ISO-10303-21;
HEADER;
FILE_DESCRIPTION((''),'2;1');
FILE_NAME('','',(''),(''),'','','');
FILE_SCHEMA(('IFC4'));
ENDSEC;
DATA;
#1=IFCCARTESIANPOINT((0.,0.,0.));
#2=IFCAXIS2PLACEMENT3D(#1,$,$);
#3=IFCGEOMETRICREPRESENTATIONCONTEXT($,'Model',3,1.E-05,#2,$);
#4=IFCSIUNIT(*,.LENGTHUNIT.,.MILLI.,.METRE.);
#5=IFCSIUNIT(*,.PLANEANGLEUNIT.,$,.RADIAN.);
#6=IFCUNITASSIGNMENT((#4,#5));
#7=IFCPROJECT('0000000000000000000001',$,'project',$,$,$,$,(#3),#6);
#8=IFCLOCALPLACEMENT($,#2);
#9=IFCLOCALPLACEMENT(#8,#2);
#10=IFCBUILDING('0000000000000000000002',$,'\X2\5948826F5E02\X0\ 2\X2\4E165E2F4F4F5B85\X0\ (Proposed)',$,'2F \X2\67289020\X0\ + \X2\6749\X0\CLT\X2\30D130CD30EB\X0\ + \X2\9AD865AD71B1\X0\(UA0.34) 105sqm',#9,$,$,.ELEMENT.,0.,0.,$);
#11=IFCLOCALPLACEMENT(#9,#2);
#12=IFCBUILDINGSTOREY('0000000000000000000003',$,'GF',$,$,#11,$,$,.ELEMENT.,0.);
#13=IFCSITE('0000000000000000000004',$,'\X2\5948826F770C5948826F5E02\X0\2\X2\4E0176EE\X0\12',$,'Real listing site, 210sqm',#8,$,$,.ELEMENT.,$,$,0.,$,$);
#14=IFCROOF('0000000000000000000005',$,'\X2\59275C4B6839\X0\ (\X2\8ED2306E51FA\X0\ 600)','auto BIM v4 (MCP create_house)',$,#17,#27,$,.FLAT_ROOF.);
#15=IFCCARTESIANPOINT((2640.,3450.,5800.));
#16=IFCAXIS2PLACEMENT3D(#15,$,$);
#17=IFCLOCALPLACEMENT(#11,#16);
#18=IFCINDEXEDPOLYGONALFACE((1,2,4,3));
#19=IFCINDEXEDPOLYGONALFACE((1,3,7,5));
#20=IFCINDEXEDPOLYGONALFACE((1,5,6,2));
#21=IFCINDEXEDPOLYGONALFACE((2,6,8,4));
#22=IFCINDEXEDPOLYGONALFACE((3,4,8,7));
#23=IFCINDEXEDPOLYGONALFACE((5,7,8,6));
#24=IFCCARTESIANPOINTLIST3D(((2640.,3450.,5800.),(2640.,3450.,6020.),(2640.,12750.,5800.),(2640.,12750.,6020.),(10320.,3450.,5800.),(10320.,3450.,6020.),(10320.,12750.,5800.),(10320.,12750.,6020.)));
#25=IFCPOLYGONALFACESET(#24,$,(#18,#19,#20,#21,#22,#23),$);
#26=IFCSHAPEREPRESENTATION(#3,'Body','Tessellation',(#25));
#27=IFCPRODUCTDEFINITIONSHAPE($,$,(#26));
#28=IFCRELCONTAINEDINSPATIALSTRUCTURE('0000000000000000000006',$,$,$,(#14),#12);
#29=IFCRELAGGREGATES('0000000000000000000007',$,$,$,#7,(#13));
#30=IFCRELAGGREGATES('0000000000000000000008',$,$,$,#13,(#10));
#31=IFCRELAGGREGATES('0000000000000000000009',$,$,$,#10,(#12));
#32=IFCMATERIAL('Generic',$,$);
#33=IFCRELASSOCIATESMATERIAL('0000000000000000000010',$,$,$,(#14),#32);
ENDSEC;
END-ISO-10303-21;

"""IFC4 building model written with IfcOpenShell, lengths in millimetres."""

from ifc_helpers import new_model, si_unit, frame, frame_2d, origin, place, context, project, spatial, rectangle, extrude, material, element, save


model = new_model("IFC4")

# Units and contexts
model_context = context("Model", 3, precision=1e-05, world=origin())
ifc_project = project(units=[si_unit("LENGTHUNIT", "METRE", prefix="MILLI"), si_unit("PLANEANGLEUNIT", "RADIAN")], contexts=[model_context])

# Site, building, storey
site_placement = place(None, origin())
site = spatial("IfcSite", under=ifc_project, at=site_placement, Name="奈良県奈良市2丁目12", ObjectType="Real listing site, 210sqm", CompositionType="ELEMENT", RefElevation=0.0)
building_placement = place(site_placement, origin())
building = spatial("IfcBuilding", under=site, at=building_placement, Name="奈良市 2世帯住宅 (Proposed)", ObjectType="2F 木造 + 杉CLTパネル + 高断熱(UA0.34) 105sqm", CompositionType="ELEMENT", ElevationOfRefHeight=0.0, ElevationOfTerrain=0.0)
storey_placement = place(building_placement, origin())
storey = spatial("IfcBuildingStorey", under=building, at=storey_placement, Name="GF", CompositionType="ELEMENT", Elevation=0.0)

# Shared definitions
ifc_material = material(Name="Generic")

# Roof
roof_placement = place(storey_placement, frame((2640.0, 3450.0, 5800.0)))
element("IfcRoof", 1, at=roof_placement, inside=storey, material=ifc_material, Name="大屋根 (軒の出 600)", Description="auto BIM v4 (MCP create_house)", PredefinedType="FLAT_ROOF", context=model_context, shape_type="SweptSolid", body=[
    extrude(rectangle(XDim=7680.0, YDim=9300.0, at=frame_2d((3840.0, 4650.0))), frame((2640.0, 3450.0, 5800.0)), (0.0, 0.0, 1.0), 220.0),
])

save(model, "model.ifc")
